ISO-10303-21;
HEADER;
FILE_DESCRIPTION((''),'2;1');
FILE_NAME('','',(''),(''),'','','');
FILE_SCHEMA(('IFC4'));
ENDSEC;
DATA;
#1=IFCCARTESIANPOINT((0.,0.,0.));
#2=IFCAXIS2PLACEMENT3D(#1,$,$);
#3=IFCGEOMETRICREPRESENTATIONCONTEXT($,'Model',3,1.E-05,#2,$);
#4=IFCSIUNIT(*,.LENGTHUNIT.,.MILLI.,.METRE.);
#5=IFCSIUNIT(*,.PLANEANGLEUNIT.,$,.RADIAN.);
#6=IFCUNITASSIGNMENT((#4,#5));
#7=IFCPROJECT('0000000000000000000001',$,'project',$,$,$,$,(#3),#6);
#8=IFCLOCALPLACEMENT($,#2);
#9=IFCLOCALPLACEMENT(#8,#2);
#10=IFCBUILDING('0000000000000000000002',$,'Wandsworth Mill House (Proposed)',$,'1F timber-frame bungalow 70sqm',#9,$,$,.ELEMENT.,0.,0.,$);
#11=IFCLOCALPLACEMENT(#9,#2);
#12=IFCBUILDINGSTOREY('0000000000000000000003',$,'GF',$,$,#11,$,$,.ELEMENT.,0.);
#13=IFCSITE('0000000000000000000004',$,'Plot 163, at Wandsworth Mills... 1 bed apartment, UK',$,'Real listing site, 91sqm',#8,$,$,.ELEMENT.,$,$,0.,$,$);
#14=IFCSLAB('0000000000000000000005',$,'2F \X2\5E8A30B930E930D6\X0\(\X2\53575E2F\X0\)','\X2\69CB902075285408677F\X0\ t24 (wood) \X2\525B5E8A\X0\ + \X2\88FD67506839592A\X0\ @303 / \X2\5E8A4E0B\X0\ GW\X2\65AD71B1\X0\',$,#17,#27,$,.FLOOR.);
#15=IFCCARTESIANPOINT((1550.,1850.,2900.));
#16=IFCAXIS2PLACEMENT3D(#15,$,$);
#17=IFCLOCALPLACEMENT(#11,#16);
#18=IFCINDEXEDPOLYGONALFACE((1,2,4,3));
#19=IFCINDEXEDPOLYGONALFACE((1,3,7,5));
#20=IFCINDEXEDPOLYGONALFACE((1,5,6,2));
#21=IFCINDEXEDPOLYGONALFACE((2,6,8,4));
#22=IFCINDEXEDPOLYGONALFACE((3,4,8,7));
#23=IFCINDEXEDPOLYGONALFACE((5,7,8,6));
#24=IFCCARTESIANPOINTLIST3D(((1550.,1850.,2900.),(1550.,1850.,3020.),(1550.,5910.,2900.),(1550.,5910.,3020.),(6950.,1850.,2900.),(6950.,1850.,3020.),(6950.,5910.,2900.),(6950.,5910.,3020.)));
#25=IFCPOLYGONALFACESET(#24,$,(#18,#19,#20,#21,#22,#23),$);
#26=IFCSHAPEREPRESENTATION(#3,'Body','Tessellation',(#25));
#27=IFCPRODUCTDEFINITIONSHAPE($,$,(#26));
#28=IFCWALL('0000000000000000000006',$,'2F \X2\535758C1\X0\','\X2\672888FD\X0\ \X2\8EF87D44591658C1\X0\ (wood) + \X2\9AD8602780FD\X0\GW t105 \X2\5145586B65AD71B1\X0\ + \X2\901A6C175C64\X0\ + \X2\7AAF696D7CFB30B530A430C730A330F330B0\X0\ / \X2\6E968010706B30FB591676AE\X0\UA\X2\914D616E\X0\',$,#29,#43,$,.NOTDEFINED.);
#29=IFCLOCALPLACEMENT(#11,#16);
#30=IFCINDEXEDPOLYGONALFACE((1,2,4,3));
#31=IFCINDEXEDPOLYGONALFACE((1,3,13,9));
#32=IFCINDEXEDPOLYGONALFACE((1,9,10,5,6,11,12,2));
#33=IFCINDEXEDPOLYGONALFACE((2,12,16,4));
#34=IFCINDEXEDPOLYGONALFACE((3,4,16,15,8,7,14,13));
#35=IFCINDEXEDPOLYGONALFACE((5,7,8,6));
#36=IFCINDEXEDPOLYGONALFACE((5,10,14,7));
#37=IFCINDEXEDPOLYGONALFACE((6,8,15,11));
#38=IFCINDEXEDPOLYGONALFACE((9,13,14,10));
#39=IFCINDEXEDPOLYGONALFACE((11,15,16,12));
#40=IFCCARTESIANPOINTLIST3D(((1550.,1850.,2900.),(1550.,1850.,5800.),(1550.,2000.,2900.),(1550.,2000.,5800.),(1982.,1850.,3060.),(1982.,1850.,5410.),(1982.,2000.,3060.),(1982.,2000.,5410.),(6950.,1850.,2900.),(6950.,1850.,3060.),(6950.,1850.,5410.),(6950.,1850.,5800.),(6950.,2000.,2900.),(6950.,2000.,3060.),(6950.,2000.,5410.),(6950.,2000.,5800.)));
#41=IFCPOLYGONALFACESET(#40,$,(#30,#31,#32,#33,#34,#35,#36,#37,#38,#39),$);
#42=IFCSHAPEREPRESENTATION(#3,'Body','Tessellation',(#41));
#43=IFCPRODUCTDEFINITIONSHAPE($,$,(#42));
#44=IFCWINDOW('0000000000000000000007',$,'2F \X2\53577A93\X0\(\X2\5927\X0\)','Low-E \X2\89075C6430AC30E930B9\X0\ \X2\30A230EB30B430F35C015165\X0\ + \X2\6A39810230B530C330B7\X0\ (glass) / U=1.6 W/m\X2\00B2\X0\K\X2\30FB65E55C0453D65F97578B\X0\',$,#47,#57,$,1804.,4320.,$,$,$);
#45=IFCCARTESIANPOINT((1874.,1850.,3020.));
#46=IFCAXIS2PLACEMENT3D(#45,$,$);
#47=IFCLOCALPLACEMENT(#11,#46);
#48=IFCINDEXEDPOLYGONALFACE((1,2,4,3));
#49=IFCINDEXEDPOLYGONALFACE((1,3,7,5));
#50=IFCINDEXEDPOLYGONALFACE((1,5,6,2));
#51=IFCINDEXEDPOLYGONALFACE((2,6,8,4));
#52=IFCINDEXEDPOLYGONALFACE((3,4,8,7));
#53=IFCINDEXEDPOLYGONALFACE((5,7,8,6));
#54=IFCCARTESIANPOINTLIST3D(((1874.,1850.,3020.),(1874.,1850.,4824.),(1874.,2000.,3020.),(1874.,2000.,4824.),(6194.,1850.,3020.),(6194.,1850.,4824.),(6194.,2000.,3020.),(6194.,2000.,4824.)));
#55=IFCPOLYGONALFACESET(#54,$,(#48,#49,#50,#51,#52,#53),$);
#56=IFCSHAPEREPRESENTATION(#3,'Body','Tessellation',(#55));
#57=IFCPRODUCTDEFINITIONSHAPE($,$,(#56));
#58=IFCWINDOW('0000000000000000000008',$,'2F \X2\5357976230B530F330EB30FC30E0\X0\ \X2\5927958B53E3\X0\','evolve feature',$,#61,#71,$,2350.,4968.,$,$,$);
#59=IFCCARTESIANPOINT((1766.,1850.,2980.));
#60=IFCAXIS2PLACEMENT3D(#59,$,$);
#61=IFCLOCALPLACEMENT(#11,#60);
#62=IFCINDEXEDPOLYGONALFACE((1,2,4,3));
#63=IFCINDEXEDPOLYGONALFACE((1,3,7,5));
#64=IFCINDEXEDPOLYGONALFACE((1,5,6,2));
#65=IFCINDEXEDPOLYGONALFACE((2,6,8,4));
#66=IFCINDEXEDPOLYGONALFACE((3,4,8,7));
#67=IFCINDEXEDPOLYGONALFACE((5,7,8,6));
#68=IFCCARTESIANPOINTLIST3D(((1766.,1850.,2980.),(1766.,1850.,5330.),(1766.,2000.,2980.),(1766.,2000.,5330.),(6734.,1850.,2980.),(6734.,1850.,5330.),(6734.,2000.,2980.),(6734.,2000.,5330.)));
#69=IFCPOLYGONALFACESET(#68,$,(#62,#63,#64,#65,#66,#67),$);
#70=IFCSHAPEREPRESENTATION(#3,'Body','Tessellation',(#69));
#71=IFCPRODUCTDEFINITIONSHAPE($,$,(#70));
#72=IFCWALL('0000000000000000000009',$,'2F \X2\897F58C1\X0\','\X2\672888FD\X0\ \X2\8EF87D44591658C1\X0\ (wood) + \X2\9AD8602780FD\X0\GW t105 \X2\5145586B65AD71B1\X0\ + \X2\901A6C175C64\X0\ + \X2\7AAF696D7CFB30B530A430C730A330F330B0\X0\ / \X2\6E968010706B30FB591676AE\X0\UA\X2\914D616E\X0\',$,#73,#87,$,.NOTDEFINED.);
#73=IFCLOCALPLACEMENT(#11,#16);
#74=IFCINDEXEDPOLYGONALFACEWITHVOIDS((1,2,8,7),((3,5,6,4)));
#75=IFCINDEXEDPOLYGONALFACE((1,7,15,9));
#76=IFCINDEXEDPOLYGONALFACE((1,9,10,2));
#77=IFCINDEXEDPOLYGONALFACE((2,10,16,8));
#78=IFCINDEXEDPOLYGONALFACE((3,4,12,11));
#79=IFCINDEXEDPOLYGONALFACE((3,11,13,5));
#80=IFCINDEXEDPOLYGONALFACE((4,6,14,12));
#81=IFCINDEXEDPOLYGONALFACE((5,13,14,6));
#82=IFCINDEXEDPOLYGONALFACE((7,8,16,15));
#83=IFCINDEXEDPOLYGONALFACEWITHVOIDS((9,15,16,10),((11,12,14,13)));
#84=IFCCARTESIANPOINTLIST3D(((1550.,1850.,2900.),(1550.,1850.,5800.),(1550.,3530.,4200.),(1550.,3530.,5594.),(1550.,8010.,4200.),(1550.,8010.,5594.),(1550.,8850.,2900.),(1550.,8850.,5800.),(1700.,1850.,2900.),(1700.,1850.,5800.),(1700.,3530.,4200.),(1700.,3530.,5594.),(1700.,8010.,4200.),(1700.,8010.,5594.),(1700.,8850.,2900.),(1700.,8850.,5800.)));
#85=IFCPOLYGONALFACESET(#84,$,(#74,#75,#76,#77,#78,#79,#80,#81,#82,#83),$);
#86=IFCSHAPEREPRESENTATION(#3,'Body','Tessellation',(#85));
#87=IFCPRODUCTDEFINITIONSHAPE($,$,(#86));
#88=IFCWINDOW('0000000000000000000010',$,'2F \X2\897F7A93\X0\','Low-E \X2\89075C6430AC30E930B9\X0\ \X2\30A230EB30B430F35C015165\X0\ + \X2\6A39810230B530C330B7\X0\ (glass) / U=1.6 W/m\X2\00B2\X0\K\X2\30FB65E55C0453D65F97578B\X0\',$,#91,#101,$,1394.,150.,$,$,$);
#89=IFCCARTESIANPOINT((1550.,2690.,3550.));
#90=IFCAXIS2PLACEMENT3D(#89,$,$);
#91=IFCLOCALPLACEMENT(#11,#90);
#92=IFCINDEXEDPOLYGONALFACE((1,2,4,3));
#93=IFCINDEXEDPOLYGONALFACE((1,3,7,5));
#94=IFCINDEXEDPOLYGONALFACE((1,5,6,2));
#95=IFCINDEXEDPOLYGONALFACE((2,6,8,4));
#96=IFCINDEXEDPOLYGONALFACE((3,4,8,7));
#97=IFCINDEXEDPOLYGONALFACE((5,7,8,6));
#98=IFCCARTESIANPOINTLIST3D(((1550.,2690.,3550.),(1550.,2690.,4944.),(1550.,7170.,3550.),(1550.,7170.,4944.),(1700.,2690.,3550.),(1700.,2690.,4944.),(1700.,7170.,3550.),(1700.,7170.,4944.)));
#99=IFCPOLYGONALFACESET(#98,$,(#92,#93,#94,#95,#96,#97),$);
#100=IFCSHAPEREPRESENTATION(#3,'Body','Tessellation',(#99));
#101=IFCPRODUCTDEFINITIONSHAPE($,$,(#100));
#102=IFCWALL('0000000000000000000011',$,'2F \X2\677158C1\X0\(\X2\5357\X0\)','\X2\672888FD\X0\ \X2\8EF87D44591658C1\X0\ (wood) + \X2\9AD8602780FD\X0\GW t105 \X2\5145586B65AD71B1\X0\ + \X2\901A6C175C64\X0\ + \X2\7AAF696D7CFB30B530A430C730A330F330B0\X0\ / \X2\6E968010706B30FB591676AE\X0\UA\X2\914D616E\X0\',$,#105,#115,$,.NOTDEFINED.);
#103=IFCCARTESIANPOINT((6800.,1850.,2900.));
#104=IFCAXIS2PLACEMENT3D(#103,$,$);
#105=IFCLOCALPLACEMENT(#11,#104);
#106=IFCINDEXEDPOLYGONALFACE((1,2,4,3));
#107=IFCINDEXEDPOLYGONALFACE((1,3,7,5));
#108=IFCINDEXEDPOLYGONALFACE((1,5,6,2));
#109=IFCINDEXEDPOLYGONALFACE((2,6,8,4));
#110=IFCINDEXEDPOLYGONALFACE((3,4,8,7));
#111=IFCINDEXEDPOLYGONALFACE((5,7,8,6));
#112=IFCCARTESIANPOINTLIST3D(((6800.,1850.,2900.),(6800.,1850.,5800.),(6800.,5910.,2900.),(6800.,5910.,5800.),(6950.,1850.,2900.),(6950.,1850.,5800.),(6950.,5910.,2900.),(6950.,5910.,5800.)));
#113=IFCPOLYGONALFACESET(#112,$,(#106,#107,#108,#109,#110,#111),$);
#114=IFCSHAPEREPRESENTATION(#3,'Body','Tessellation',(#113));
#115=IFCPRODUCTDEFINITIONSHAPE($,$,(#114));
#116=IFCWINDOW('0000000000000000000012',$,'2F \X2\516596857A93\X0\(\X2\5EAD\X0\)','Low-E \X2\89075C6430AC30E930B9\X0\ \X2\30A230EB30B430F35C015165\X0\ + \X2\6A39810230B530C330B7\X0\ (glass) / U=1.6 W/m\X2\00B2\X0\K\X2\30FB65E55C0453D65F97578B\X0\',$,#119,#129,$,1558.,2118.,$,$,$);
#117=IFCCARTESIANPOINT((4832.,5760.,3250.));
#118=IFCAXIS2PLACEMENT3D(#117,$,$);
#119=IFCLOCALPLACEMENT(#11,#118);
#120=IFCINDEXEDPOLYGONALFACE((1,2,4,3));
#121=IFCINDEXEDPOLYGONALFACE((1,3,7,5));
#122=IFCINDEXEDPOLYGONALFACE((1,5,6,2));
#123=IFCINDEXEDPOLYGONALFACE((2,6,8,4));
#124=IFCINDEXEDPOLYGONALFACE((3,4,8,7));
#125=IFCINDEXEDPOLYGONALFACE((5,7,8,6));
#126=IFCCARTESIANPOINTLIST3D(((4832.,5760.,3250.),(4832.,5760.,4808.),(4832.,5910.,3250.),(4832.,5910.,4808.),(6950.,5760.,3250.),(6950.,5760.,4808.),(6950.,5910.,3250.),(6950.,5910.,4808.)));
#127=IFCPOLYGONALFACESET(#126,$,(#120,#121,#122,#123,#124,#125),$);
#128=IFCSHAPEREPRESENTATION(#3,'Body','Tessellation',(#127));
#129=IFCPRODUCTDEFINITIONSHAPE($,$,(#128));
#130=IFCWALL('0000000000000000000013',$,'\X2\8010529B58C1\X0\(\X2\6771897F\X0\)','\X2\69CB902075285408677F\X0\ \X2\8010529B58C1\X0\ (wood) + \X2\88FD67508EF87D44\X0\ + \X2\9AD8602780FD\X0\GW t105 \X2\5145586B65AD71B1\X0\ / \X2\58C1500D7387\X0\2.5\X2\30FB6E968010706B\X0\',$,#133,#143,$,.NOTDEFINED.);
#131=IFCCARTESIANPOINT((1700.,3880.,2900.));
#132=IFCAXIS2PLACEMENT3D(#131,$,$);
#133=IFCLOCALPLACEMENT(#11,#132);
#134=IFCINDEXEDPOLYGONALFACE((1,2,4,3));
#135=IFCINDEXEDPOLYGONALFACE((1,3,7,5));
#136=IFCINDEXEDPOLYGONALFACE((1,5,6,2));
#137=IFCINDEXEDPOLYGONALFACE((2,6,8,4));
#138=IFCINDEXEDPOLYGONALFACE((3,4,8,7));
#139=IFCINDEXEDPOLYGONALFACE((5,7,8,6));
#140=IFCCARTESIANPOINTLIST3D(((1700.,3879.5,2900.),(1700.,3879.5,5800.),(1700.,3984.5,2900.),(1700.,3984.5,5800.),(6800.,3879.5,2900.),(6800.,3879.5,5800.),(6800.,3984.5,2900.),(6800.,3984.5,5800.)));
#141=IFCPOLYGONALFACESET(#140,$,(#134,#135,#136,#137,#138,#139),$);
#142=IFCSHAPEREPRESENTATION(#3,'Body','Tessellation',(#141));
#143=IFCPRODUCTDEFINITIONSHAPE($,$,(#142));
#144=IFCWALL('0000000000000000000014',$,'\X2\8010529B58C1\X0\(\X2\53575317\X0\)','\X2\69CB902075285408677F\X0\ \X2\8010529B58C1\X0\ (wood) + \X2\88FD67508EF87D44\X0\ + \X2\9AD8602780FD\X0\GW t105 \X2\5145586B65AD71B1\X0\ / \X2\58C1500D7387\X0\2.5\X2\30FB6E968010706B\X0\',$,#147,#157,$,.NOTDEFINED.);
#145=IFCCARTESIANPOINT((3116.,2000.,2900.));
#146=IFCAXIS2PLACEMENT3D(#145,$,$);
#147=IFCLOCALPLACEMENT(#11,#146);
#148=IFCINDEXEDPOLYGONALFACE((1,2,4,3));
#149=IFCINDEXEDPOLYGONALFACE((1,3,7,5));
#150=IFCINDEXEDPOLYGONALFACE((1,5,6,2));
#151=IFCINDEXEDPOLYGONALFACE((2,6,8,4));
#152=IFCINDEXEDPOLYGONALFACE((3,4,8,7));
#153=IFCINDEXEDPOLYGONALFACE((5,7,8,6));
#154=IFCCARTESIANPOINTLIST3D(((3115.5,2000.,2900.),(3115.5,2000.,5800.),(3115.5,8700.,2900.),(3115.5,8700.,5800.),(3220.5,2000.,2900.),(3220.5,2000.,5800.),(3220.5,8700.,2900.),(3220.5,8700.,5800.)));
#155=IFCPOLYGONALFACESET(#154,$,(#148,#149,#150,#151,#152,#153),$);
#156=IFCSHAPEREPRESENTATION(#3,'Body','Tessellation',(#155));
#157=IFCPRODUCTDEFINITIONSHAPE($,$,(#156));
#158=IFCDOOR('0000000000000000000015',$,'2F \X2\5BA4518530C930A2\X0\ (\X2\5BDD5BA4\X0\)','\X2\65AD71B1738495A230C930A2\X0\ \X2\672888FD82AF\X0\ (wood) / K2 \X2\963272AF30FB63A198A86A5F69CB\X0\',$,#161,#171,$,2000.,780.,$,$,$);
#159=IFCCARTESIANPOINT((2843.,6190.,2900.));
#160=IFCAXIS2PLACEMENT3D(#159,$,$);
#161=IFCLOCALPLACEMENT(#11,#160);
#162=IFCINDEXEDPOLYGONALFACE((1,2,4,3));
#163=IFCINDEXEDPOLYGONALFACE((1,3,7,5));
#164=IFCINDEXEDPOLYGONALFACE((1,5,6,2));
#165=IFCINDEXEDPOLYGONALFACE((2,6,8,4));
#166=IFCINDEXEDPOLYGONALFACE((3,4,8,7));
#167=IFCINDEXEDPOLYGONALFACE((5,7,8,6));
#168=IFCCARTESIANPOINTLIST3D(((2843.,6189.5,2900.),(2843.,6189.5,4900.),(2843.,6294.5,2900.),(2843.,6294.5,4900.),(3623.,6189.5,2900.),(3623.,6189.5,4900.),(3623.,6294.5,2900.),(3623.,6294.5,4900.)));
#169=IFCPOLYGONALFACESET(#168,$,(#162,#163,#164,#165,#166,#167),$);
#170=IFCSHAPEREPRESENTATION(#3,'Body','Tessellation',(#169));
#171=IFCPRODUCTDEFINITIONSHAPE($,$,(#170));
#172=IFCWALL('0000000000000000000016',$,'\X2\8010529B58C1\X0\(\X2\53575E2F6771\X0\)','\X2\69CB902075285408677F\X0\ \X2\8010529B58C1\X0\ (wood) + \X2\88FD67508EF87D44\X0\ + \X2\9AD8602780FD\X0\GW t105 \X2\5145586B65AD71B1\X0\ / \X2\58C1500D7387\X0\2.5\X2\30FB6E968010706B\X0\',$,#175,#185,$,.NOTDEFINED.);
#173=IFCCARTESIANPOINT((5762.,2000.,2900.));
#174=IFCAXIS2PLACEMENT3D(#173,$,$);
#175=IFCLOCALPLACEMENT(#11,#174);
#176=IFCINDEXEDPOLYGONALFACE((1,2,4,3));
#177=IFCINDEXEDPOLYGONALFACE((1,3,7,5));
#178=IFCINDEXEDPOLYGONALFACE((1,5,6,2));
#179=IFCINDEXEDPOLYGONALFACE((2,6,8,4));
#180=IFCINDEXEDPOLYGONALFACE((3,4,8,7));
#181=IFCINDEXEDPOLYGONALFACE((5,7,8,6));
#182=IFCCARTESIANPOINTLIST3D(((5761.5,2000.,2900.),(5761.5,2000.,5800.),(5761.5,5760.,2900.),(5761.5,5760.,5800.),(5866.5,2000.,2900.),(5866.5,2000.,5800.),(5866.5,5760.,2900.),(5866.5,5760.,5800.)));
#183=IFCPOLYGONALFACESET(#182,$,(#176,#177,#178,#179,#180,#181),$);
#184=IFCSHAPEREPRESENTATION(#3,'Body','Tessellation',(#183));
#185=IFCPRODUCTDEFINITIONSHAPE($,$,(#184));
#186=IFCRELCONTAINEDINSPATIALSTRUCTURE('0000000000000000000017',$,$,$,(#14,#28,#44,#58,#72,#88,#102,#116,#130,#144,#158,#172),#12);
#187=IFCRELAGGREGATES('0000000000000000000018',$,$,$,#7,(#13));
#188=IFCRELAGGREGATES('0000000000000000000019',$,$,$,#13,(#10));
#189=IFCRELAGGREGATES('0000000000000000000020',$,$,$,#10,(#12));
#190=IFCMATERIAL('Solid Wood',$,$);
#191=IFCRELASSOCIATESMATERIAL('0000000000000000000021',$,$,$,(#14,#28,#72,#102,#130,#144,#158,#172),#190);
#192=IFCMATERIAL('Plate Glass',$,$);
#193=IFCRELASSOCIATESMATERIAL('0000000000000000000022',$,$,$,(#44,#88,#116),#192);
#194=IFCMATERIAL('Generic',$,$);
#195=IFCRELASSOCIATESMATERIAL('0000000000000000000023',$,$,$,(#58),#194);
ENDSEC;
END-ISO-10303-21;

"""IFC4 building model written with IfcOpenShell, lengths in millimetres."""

from ifc_helpers import new_model, si_unit, frame, frame_2d, origin, place, context, project, spatial, rectangle, extrude, material, element, fill, save


model = new_model("IFC4")

# Units and contexts
model_context = context("Model", 3, precision=1e-05, world=origin())
ifc_project = project(units=[si_unit("LENGTHUNIT", "METRE", prefix="MILLI"), si_unit("PLANEANGLEUNIT", "RADIAN")], contexts=[model_context])

# Site, building, storey
site_placement = place(None, origin())
site = spatial("IfcSite", under=ifc_project, at=site_placement, Name="Plot 163, at Wandsworth Mills... 1 bed apartment, UK", ObjectType="Real listing site, 91sqm", CompositionType="ELEMENT", RefElevation=0.0)
building_placement = place(site_placement, origin())
building = spatial("IfcBuilding", under=site, at=building_placement, Name="Wandsworth Mill House (Proposed)", ObjectType="1F timber-frame bungalow 70sqm", CompositionType="ELEMENT", ElevationOfRefHeight=0.0, ElevationOfTerrain=0.0)
storey_placement = place(building_placement, origin())
storey = spatial("IfcBuildingStorey", under=building, at=storey_placement, Name="GF", CompositionType="ELEMENT", Elevation=0.0)

# Slab
ifc_material_1 = material(Name="Solid Wood")
slab_placement = place(storey_placement, frame((1550.0, 1850.0, 2900.0)))
element("IfcSlab", 1, at=slab_placement, inside=storey, material=ifc_material_1, Name="2F 床スラブ(南帯)", Description="構造用合板 t24 (wood) 剛床 + 製材根太 @303 / 床下 GW断熱", PredefinedType="FLOOR", context=model_context, shape_type="SweptSolid", body=[
    extrude(rectangle(XDim=5400.0, YDim=4060.0, at=frame_2d((2700.0, 2030.0))), frame((1550.0, 1850.0, 2900.0)), (0.0, 0.0, 1.0), 120.0),
])

# Wall, openings, windows
wall_1_placement = place(storey_placement, frame((1550.0, 1850.0, 2900.0)))
wall_1 = element("IfcWall", 2, at=wall_1_placement, inside=storey, material=ifc_material_1, Name="2F 南壁", Description="木製 軸組外壁 (wood) + 高性能GW t105 充填断熱 + 通気層 + 窯業系サイディング / 準耐火・外皮UA配慮", PredefinedType="NOTDEFINED", context=model_context, shape_type="SweptSolid", body=[
    extrude(rectangle(XDim=5400.0, YDim=150.0, at=frame_2d((2700.0, 75.0))), frame((1550.0, 1850.0, 2900.0)), (0.0, 0.0, 1.0), 2900.0),
])
opening_1_placement = place(storey_placement, frame((1874.0, 1850.0, 3020.0)))
opening_1 = element("IfcOpeningElement", 3, at=opening_1_placement, cuts=wall_1, PredefinedType="NOTDEFINED", context=model_context, shape_type="SweptSolid", body=[
    extrude(rectangle(XDim=4320.0, YDim=150.0, at=frame_2d((2160.0, 75.0))), frame((1874.0, 1850.0, 3020.0)), (0.0, 0.0, 1.0), 1804.0),
])
opening_2_placement = place(storey_placement, frame((1766.0, 1850.0, 2980.0)))
opening_2 = element("IfcOpeningElement", 4, at=opening_2_placement, cuts=wall_1, PredefinedType="NOTDEFINED", context=model_context, shape_type="SweptSolid", body=[
    extrude(rectangle(XDim=4968.0, YDim=150.0, at=frame_2d((2484.0, 75.0))), frame((1766.0, 1850.0, 2980.0)), (0.0, 0.0, 1.0), 2350.0),
])
ifc_material_2 = material(Name="Plate Glass")
window_1_placement = place(storey_placement, frame((1874.0, 1850.0, 3020.0)))
window_1 = element("IfcWindow", 5, at=window_1_placement, inside=storey, material=ifc_material_2, Name="2F 南窓(大)", Description="Low-E 複層ガラス アルゴン封入 + 樹脂サッシ (glass) / U=1.6 W/m²K・日射取得型", OverallHeight=1804.0, OverallWidth=4320.0, context=model_context, shape_type="SweptSolid", body=[
    extrude(rectangle(XDim=4320.0, YDim=150.0, at=frame_2d((2160.0, 75.0))), frame((1874.0, 1850.0, 3020.0)), (0.0, 0.0, 1.0), 1804.0),
])
fill(opening_1, window_1)
ifc_material_3 = material(Name="Generic")
window_2_placement = place(storey_placement, frame((1766.0, 1850.0, 2980.0)))
window_2 = element("IfcWindow", 6, at=window_2_placement, inside=storey, material=ifc_material_3, Name="2F 南面サンルーム 大開口", Description="evolve feature", OverallHeight=2350.0, OverallWidth=4968.0, context=model_context, shape_type="SweptSolid", body=[
    extrude(rectangle(XDim=4968.0, YDim=150.0, at=frame_2d((2484.0, 75.0))), frame((1766.0, 1850.0, 2980.0)), (0.0, 0.0, 1.0), 2350.0),
])
fill(opening_2, window_2)

# Walls, openings, windows
wall_2_placement = place(storey_placement, frame((1550.0, 1850.0, 2900.0)))
wall_2 = element("IfcWall", 7, at=wall_2_placement, inside=storey, material=ifc_material_1, Name="2F 西壁", Description="木製 軸組外壁 (wood) + 高性能GW t105 充填断熱 + 通気層 + 窯業系サイディング / 準耐火・外皮UA配慮", PredefinedType="NOTDEFINED", context=model_context, shape_type="SweptSolid", body=[
    extrude(rectangle(XDim=150.0, YDim=7000.0, at=frame_2d((75.0, 3500.0))), frame((1550.0, 1850.0, 2900.0)), (0.0, 0.0, 1.0), 2900.0),
])
opening_3_placement = place(storey_placement, frame((1550.0, 2690.0, 3550.0)))
opening_3 = element("IfcOpeningElement", 8, at=opening_3_placement, cuts=wall_2, PredefinedType="NOTDEFINED", context=model_context, shape_type="SweptSolid", body=[
    extrude(rectangle(XDim=150.0, YDim=4480.0, at=frame_2d((75.0, 2240.0))), frame((1550.0, 2690.0, 3550.0)), (0.0, 0.0, 1.0), 1394.0),
])
window_3_placement = place(storey_placement, frame((1550.0, 2690.0, 3550.0)))
window_3 = element("IfcWindow", 9, at=window_3_placement, inside=storey, material=ifc_material_2, Name="2F 西窓", Description="Low-E 複層ガラス アルゴン封入 + 樹脂サッシ (glass) / U=1.6 W/m²K・日射取得型", OverallHeight=1394.0, OverallWidth=150.0, context=model_context, shape_type="SweptSolid", body=[
    extrude(rectangle(XDim=150.0, YDim=4480.0, at=frame_2d((75.0, 2240.0))), frame((1550.0, 2690.0, 3550.0)), (0.0, 0.0, 1.0), 1394.0),
])
fill(opening_3, window_3)
wall_3_placement = place(storey_placement, frame((6800.0, 1850.0, 2900.0)))
wall_3 = element("IfcWall", 10, at=wall_3_placement, inside=storey, material=ifc_material_1, Name="2F 東壁(南)", Description="木製 軸組外壁 (wood) + 高性能GW t105 充填断熱 + 通気層 + 窯業系サイディング / 準耐火・外皮UA配慮", PredefinedType="NOTDEFINED", context=model_context, shape_type="SweptSolid", body=[
    extrude(rectangle(XDim=150.0, YDim=4060.0, at=frame_2d((75.0, 2030.0))), frame((6800.0, 1850.0, 2900.0)), (0.0, 0.0, 1.0), 2900.0),
])
opening_4_placement = place(storey_placement, frame((4832.0, 5760.0, 3250.0)))
opening_4 = element("IfcOpeningElement", 11, at=opening_4_placement, cuts=wall_3, PredefinedType="NOTDEFINED", context=model_context, shape_type="SweptSolid", body=[
    extrude(rectangle(XDim=2118.0, YDim=150.0, at=frame_2d((1059.0, 75.0))), frame((4832.0, 5760.0, 3250.0)), (0.0, 0.0, 1.0), 1558.0),
])
window_4_placement = place(storey_placement, frame((4832.0, 5760.0, 3250.0)))
window_4 = element("IfcWindow", 12, at=window_4_placement, inside=storey, material=ifc_material_2, Name="2F 入隅窓(庭)", Description="Low-E 複層ガラス アルゴン封入 + 樹脂サッシ (glass) / U=1.6 W/m²K・日射取得型", OverallHeight=1558.0, OverallWidth=2118.0, context=model_context, shape_type="SweptSolid", body=[
    extrude(rectangle(XDim=2118.0, YDim=150.0, at=frame_2d((1059.0, 75.0))), frame((4832.0, 5760.0, 3250.0)), (0.0, 0.0, 1.0), 1558.0),
])
fill(opening_4, window_4)

# Wall
wall_4_placement = place(storey_placement, frame((1700.0, 3880.0, 2900.0)))
element("IfcWall", 13, at=wall_4_placement, inside=storey, material=ifc_material_1, Name="耐力壁(東西)", Description="構造用合板 耐力壁 (wood) + 製材軸組 + 高性能GW t105 充填断熱 / 壁倍率2.5・準耐火", PredefinedType="NOTDEFINED", context=model_context, shape_type="SweptSolid", body=[
    extrude(rectangle(XDim=5100.0, YDim=105.0, at=frame_2d((2550.0, 52.0))), frame((1700.0, 3880.0, 2900.0)), (0.0, 0.0, 1.0), 2900.0),
])

# Wall, opening, door
wall_5_placement = place(storey_placement, frame((3116.0, 2000.0, 2900.0)))
wall_5 = element("IfcWall", 14, at=wall_5_placement, inside=storey, material=ifc_material_1, Name="耐力壁(南北)", Description="構造用合板 耐力壁 (wood) + 製材軸組 + 高性能GW t105 充填断熱 / 壁倍率2.5・準耐火", PredefinedType="NOTDEFINED", context=model_context, shape_type="SweptSolid", body=[
    extrude(rectangle(XDim=105.0, YDim=6700.0, at=frame_2d((52.0, 3350.0))), frame((3116.0, 2000.0, 2900.0)), (0.0, 0.0, 1.0), 2900.0),
])
opening_5_placement = place(storey_placement, frame((2843.0, 6190.0, 2900.0)))
opening_5 = element("IfcOpeningElement", 15, at=opening_5_placement, cuts=wall_5, PredefinedType="NOTDEFINED", context=model_context, shape_type="SweptSolid", body=[
    extrude(rectangle(XDim=780.0, YDim=105.0, at=frame_2d((390.0, 52.0))), frame((2843.0, 6190.0, 2900.0)), (0.0, 0.0, 1.0), 2000.0),
])
door_placement = place(storey_placement, frame((2843.0, 6190.0, 2900.0)))
door = element("IfcDoor", 16, at=door_placement, inside=storey, material=ifc_material_1, Name="2F 室内ドア (寝室)", Description="断熱玄関ドア 木製芯 (wood) / K2 防犯・採風機構", OverallHeight=2000.0, OverallWidth=780.0, context=model_context, shape_type="SweptSolid", body=[
    extrude(rectangle(XDim=780.0, YDim=105.0, at=frame_2d((390.0, 52.0))), frame((2843.0, 6190.0, 2900.0)), (0.0, 0.0, 1.0), 2000.0),
])
fill(opening_5, door)

# Wall
wall_6_placement = place(storey_placement, frame((5762.0, 2000.0, 2900.0)))
element("IfcWall", 17, at=wall_6_placement, inside=storey, material=ifc_material_1, Name="耐力壁(南帯東)", Description="構造用合板 耐力壁 (wood) + 製材軸組 + 高性能GW t105 充填断熱 / 壁倍率2.5・準耐火", PredefinedType="NOTDEFINED", context=model_context, shape_type="SweptSolid", body=[
    extrude(rectangle(XDim=105.0, YDim=3760.0, at=frame_2d((52.0, 1880.0))), frame((5762.0, 2000.0, 2900.0)), (0.0, 0.0, 1.0), 2900.0),
])

save(model, "model.ifc")
